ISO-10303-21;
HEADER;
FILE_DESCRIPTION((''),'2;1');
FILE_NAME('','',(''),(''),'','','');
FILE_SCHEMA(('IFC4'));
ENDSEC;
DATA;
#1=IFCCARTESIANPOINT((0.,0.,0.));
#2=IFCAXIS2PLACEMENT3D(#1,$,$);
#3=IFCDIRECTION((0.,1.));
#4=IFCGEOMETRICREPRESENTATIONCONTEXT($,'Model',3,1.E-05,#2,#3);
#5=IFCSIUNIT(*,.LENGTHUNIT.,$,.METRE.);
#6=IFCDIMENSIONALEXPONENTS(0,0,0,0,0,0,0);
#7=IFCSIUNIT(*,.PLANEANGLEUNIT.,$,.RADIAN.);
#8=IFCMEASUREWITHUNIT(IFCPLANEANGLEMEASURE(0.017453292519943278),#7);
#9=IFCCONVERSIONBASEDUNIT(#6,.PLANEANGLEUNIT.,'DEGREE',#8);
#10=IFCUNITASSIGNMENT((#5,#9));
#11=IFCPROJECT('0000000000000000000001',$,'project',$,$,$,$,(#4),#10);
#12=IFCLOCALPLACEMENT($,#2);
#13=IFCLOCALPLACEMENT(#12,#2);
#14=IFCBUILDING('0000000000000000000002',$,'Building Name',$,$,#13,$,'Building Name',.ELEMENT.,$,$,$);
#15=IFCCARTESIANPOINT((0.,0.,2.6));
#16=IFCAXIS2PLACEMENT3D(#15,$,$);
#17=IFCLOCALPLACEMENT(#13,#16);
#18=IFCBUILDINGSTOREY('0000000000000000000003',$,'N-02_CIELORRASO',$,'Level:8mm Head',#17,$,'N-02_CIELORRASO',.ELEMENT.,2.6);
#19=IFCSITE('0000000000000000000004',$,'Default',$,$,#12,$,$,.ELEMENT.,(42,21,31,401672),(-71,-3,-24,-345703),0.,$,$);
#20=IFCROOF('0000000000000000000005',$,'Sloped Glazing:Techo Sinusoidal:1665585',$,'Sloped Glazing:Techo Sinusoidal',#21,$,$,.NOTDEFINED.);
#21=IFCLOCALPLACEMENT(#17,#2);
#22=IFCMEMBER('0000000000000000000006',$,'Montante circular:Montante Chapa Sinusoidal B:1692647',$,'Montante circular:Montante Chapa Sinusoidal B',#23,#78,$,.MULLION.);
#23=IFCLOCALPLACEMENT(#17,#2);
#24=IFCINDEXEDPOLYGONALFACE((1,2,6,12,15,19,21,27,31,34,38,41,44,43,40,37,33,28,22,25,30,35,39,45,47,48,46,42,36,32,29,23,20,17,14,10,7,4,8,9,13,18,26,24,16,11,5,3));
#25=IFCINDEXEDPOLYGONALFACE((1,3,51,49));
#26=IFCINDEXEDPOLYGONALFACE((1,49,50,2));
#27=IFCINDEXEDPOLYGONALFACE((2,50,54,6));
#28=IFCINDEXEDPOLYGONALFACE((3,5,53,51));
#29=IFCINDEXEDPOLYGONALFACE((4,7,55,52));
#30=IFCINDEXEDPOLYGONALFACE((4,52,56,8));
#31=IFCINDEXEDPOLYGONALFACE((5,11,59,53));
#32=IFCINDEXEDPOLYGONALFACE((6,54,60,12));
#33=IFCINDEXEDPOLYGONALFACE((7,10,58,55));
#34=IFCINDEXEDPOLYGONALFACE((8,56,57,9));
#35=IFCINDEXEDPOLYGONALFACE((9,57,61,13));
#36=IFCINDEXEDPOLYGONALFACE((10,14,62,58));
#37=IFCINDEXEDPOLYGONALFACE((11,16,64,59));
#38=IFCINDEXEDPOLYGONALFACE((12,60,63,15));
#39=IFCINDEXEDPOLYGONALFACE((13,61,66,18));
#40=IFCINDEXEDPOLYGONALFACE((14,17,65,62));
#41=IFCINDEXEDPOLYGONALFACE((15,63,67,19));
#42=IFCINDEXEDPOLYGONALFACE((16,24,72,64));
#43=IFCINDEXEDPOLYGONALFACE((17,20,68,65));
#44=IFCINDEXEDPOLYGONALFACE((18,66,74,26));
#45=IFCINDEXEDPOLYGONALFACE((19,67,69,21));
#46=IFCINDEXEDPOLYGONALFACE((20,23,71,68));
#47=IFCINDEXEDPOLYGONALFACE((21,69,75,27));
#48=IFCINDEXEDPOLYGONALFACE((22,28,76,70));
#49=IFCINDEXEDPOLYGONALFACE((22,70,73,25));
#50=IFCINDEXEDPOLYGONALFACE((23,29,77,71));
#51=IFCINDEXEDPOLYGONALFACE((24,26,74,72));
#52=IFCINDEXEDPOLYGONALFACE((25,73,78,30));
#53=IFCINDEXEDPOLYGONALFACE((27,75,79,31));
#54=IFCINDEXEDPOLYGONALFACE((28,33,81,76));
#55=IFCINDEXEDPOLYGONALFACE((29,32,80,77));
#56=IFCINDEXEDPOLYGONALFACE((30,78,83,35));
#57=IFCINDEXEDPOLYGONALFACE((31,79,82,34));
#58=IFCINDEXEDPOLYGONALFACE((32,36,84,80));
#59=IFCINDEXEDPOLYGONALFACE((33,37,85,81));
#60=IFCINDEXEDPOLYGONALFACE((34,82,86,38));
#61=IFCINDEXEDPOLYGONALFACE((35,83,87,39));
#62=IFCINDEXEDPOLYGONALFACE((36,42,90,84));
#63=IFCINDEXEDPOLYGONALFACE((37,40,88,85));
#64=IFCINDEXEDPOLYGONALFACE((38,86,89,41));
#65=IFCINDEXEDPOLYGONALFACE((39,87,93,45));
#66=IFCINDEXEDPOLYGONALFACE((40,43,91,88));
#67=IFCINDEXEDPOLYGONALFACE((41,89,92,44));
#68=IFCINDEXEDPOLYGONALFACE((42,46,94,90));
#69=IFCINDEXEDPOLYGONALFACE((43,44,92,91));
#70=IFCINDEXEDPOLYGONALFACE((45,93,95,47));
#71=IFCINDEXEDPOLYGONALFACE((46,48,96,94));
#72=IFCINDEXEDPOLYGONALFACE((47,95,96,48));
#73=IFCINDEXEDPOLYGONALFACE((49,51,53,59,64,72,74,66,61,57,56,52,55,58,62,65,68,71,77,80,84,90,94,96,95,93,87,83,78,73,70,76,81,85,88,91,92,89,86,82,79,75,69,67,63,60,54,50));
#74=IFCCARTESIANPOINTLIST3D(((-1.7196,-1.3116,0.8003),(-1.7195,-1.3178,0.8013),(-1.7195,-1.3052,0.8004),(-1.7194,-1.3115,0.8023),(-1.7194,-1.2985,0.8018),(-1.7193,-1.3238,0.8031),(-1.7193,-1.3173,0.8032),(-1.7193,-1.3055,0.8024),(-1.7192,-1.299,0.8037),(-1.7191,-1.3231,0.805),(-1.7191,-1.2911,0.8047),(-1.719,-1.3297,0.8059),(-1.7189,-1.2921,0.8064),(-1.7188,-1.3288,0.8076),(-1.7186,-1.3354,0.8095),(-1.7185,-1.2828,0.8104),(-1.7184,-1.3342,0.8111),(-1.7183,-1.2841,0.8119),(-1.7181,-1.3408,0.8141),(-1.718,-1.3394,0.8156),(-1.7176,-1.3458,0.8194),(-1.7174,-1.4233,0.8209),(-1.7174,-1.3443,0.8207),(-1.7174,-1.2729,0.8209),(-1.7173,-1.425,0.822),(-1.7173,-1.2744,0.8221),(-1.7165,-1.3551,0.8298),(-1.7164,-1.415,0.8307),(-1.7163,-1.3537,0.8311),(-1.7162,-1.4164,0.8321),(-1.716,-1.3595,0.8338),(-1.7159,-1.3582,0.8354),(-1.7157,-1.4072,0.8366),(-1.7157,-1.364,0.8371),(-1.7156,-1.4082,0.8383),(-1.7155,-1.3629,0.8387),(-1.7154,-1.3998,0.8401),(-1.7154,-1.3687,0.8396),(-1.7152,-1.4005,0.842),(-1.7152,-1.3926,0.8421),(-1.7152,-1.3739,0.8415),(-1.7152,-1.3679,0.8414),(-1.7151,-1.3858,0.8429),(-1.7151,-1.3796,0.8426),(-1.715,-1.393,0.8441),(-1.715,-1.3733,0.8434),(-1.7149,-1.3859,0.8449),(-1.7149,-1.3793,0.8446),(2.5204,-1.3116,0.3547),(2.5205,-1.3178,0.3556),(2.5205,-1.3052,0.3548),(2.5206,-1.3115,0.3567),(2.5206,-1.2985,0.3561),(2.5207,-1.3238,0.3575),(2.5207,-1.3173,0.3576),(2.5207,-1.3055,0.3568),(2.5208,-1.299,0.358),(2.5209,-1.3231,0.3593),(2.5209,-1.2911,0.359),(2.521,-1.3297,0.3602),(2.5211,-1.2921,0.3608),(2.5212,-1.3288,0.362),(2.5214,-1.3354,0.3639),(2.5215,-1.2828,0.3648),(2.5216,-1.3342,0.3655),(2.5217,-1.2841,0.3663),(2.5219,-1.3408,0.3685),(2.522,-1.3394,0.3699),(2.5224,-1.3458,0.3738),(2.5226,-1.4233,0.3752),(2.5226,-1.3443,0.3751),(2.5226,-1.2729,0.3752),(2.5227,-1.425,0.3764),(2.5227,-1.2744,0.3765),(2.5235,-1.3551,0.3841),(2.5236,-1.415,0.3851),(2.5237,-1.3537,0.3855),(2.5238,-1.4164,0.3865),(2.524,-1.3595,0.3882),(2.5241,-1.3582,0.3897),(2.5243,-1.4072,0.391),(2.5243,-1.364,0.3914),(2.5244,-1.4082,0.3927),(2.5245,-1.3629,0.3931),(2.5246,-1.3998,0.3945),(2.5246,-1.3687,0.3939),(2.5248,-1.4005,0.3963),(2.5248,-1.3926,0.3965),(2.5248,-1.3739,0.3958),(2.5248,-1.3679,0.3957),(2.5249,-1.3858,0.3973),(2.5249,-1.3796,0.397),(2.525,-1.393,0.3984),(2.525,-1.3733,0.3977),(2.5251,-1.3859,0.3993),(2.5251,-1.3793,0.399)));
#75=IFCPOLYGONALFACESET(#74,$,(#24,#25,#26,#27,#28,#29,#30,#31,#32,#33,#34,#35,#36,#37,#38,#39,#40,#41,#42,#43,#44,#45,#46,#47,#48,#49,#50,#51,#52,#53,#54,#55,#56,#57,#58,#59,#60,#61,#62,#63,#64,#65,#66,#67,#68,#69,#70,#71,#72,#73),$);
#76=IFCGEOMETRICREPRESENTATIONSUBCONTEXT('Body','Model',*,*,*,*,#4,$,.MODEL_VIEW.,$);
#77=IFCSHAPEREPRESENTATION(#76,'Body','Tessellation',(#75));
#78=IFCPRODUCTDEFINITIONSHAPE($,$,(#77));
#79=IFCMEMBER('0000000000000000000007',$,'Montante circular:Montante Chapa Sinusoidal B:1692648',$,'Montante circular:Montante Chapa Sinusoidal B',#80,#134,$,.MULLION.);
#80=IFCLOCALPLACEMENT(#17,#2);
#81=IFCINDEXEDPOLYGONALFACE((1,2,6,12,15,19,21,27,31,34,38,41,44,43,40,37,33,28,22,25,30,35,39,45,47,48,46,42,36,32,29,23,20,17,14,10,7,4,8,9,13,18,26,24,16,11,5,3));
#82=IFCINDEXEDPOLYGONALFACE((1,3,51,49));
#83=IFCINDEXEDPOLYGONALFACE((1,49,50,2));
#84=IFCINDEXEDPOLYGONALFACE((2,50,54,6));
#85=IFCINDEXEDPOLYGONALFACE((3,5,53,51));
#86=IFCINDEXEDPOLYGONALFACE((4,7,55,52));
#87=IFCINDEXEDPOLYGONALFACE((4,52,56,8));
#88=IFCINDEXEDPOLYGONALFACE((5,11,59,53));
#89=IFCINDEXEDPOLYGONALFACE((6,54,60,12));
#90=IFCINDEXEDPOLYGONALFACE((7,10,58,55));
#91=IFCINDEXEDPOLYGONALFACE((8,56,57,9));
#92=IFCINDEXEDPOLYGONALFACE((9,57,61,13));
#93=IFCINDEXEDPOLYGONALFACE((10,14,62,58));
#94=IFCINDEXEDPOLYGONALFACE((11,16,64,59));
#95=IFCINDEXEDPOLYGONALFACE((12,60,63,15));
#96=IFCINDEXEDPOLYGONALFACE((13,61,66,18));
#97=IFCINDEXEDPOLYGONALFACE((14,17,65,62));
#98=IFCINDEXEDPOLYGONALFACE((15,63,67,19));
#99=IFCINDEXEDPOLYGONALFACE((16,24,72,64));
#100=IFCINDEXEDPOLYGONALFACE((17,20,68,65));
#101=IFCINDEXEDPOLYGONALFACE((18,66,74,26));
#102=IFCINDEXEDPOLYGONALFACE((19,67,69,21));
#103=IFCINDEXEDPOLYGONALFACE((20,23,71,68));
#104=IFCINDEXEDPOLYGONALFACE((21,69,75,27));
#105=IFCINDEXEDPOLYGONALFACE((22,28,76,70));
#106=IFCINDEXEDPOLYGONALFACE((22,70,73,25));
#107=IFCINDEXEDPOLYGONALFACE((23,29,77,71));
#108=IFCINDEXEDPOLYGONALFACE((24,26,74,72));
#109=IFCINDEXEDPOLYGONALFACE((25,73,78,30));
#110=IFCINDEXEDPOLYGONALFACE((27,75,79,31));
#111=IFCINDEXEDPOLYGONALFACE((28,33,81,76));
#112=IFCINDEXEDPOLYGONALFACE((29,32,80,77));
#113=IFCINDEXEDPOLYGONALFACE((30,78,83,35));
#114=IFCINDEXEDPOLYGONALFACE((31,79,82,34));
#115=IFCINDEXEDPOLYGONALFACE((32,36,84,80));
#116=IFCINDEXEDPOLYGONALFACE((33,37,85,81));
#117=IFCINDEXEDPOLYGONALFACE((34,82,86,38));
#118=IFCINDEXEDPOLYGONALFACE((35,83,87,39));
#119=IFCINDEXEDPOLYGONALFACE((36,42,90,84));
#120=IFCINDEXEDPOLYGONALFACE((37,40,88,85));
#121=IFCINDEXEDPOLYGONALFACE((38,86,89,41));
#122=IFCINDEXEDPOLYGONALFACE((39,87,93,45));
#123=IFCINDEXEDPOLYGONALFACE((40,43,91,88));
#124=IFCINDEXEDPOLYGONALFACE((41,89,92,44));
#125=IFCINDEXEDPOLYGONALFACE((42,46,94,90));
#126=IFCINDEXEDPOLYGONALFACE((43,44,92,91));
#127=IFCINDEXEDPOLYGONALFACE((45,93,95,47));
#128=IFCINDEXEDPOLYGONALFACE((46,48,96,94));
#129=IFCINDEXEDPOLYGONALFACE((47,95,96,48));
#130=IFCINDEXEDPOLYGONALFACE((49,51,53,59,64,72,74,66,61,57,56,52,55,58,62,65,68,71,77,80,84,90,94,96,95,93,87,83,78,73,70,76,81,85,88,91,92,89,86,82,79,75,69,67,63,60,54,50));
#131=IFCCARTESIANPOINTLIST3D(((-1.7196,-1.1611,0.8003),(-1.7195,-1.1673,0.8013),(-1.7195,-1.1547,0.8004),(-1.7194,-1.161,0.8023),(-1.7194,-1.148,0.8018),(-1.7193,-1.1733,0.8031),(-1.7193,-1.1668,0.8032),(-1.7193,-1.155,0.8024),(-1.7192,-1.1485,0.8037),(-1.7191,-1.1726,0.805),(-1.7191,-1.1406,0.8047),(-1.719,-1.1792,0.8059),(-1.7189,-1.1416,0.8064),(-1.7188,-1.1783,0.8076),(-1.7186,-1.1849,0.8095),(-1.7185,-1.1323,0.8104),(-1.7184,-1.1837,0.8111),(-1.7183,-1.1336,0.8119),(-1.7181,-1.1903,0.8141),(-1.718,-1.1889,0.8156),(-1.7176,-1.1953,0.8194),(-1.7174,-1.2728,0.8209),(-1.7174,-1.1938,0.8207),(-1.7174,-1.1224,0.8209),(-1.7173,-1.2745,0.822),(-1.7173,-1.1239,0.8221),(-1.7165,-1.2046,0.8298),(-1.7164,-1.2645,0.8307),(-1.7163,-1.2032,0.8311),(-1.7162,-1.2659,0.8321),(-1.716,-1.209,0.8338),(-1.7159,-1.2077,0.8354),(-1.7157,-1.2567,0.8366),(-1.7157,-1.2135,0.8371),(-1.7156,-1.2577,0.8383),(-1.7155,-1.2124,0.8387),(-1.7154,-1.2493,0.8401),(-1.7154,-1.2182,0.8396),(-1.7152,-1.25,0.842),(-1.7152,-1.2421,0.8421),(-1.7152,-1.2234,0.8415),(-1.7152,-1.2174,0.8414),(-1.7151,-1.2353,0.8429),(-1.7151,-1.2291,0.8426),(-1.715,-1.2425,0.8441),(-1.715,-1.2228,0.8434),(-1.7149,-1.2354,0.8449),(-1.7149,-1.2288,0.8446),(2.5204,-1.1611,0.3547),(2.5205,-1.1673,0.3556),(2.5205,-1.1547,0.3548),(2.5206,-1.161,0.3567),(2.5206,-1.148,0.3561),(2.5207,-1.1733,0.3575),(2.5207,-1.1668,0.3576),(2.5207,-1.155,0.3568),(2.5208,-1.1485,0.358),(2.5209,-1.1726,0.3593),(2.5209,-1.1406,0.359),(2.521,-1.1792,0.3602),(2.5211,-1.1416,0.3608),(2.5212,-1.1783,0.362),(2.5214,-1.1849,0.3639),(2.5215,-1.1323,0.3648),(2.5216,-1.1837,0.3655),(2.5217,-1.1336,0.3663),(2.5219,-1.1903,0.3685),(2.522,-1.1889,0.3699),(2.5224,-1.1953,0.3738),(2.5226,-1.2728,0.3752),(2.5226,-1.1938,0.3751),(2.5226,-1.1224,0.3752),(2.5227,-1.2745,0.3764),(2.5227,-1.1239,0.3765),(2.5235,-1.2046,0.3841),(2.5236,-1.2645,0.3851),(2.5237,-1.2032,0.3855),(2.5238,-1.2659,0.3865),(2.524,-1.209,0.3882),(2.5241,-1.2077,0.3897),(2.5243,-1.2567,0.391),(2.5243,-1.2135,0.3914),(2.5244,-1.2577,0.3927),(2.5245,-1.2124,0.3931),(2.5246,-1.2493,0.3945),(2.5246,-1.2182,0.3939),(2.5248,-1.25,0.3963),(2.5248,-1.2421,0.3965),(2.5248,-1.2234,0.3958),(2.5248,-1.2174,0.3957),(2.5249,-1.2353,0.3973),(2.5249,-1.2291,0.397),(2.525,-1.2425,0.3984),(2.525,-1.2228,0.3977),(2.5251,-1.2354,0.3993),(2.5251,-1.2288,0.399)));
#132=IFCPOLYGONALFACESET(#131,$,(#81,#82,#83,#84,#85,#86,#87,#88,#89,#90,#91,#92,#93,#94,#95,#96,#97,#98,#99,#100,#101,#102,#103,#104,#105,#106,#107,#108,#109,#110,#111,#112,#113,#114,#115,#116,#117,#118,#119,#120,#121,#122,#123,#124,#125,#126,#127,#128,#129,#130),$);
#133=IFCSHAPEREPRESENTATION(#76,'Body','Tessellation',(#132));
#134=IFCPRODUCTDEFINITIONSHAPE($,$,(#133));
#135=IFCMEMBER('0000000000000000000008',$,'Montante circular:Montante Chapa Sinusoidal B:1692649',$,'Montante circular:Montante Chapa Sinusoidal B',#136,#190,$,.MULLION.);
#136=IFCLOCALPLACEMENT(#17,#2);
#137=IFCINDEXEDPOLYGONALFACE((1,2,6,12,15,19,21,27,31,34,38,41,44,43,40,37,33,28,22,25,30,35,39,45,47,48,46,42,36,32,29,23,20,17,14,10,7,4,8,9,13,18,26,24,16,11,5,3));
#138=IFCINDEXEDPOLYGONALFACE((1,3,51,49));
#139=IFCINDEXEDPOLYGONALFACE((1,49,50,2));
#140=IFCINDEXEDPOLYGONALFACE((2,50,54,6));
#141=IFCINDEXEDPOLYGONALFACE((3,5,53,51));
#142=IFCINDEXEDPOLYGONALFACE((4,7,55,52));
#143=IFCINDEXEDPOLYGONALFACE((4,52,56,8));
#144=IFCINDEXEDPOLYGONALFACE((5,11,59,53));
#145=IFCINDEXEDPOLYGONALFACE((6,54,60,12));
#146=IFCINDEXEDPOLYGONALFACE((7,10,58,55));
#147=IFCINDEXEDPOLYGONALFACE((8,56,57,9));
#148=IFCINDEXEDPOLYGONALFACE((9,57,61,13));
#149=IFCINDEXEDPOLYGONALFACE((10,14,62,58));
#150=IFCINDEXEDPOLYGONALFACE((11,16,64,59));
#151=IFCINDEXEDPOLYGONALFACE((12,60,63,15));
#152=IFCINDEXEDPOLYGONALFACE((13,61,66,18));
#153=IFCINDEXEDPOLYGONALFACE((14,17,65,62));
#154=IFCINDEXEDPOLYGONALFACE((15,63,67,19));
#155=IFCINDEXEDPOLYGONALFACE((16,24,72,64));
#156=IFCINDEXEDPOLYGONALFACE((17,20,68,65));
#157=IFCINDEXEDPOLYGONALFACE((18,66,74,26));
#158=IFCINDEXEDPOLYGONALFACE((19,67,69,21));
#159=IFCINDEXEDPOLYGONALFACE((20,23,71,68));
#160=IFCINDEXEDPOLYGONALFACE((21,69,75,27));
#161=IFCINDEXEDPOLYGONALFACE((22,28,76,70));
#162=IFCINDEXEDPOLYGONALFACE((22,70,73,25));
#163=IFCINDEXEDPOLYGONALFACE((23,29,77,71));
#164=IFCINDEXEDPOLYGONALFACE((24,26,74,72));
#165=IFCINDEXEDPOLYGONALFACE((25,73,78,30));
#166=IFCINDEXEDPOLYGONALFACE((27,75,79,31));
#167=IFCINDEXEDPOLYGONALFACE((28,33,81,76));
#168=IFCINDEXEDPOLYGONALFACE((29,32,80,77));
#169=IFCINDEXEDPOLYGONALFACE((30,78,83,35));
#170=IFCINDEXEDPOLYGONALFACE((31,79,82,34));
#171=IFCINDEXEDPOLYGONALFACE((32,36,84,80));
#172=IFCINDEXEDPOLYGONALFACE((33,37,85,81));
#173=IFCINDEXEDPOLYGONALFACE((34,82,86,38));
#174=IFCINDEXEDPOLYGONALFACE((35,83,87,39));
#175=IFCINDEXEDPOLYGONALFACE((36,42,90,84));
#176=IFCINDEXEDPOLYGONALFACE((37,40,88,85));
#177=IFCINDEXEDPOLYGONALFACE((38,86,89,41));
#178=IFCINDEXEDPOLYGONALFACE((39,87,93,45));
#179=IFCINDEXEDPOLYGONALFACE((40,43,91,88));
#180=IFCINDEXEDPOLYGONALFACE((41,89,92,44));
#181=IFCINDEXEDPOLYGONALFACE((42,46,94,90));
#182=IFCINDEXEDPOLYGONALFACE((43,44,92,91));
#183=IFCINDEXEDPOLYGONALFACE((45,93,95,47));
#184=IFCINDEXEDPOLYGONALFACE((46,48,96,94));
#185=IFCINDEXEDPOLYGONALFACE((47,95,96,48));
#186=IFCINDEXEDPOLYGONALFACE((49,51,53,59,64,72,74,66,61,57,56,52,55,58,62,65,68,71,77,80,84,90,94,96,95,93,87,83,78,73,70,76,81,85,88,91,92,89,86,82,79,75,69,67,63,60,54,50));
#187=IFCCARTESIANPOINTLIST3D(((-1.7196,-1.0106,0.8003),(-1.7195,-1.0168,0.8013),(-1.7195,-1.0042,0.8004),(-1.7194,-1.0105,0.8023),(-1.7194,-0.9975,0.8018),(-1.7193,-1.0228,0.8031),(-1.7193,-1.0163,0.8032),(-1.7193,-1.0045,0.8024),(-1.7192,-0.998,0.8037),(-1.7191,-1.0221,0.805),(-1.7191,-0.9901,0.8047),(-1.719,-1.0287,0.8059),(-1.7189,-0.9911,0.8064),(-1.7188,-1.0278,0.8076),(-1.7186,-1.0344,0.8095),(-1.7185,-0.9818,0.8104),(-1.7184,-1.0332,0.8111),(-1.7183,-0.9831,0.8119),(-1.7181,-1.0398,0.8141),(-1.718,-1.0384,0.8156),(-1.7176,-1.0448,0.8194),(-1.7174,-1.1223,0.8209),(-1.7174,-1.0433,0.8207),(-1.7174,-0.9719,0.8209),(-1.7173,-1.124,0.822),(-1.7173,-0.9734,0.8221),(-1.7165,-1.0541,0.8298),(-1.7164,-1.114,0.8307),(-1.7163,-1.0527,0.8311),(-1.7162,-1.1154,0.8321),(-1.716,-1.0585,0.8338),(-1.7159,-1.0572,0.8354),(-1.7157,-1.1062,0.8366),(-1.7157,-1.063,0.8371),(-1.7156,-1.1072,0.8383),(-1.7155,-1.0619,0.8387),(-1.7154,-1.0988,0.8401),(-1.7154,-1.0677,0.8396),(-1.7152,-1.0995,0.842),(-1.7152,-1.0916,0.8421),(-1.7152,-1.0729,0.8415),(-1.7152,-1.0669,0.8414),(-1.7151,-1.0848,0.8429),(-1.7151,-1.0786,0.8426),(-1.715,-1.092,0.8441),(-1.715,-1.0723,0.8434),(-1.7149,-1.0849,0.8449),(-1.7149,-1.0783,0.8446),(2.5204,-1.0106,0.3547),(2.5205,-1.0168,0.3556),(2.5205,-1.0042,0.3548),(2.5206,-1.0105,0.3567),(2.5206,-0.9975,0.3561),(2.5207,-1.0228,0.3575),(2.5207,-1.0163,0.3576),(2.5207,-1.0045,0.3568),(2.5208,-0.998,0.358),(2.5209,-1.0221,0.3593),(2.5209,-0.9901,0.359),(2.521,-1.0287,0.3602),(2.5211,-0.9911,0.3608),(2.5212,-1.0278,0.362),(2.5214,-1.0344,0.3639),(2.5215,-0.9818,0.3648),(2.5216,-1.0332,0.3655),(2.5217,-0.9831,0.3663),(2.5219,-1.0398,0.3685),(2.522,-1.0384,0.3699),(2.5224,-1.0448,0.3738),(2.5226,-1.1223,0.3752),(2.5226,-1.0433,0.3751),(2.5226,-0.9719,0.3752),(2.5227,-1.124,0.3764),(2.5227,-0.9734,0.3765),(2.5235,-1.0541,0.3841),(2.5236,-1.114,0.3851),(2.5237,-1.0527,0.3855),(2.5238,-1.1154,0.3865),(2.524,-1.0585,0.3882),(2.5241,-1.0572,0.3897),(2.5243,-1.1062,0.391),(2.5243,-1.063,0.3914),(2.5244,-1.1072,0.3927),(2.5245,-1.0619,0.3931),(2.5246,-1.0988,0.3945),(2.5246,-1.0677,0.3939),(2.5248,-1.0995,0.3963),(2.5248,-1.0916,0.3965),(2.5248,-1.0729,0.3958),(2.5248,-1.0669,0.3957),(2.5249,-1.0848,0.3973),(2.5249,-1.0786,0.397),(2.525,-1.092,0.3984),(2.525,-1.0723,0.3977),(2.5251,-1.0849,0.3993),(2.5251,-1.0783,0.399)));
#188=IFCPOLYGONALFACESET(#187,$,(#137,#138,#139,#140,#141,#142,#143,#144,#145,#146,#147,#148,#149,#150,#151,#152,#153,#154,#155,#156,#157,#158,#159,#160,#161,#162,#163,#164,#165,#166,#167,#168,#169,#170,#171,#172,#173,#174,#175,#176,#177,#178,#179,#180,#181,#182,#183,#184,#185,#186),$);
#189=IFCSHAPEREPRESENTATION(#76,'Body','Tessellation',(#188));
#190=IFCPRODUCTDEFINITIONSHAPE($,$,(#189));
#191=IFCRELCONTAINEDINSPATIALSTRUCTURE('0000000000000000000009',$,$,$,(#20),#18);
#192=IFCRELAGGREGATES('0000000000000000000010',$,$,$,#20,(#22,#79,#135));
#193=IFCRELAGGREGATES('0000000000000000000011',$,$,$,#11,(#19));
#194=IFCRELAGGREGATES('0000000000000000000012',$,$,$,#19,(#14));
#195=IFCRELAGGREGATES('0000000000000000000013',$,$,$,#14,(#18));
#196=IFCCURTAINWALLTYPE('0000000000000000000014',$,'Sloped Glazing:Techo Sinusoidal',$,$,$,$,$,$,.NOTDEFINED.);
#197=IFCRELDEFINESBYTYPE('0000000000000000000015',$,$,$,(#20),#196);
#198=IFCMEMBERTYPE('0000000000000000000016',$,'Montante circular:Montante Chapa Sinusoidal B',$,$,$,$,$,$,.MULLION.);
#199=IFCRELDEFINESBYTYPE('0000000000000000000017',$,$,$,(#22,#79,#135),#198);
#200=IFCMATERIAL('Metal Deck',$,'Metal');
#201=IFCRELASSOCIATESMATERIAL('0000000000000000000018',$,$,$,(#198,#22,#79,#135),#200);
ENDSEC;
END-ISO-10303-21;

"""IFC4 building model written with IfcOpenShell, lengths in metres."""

from ifc_helpers import new_model, entity, si_unit, converted_unit, direction, frame, origin, place, context, subcontext, project, spatial, indexed_curve, outline, extrude, source, transform, mapped, material, type_object, type_shapes, element, aggregate, save


model = new_model("IFC4")

# Units and contexts
model_context = context("Model", 3, precision=1e-05, world=origin(), true_north=direction((0.0, 1.0)))
body_context = subcontext(model_context, "Body", "Model", "MODEL_VIEW")
ifc_project = project(units=[si_unit("LENGTHUNIT", "METRE"), converted_unit("PLANEANGLEUNIT", "DEGREE", entity("IfcPlaneAngleMeasure", 0.017453292519943278), si_unit("PLANEANGLEUNIT", "RADIAN"), dimensions=[0, 0, 0, 0, 0, 0, 0])], contexts=[model_context])

# Site, building, storey
site_placement = place(None, origin())
site = spatial("IfcSite", under=ifc_project, at=site_placement, Name="Default", CompositionType="ELEMENT", RefLatitude=(42, 21, 31, 401672), RefLongitude=(-71, -3, -24, -345703), RefElevation=0.0)
building_placement = place(site_placement, origin())
building = spatial("IfcBuilding", under=site, at=building_placement, Name="Building Name", LongName="Building Name", CompositionType="ELEMENT")
storey_placement = place(building_placement, frame((0.0, 0.0, 2.6)))
storey = spatial("IfcBuildingStorey", under=building, at=storey_placement, Name="N-02_CIELORRASO", ObjectType="Level:8mm Head", LongName="N-02_CIELORRASO", CompositionType="ELEMENT", Elevation=2.6)

# Roof, members
curtain_wall_type = type_object("IfcCurtainWallType", Name="Sloped Glazing:Techo Sinusoidal", PredefinedType="NOTDEFINED")
roof_1_placement = place(storey_placement, frame((0.0, 0.0, -2.6)))
roof_1 = element("IfcRoof", 1, at=roof_1_placement, inside=storey, type_object=curtain_wall_type, Name="Sloped Glazing:Techo Sinusoidal:1665585", ObjectType="Sloped Glazing:Techo Sinusoidal", PredefinedType="NOTDEFINED")
ifc_material = material(Name="Metal Deck", Category="Metal")
member_type_1 = type_object("IfcMemberType", Name="Montante circular:Montante Chapa Sinusoidal B", PredefinedType="MULLION", material=ifc_material)
shared_shape_1 = source(origin(), body_context, "Body", "SweptSolid", [
    extrude(outline(indexed_curve([(0.0595, -0.0443), (0.0615, -0.0443), (0.0603, -0.031), (0.0572, -0.0213), (0.053, -0.0138), (0.0481, -0.0078), (0.0427, -0.003), (0.0372, 0.0005), (0.0315, 0.0029), (0.0259, 0.0044), (0.0203, 0.0051), (0.0146, 0.005), (0.0084, 0.0041), (-0.0053, 0.0009), (-0.0123, -0.0005), (-0.0191, -0.0012), (-0.0256, -0.001), (-0.0317, 0.0001), (-0.0375, 0.0019), (-0.0428, 0.0046), (-0.0477, 0.0081), (-0.0522, 0.0128), (-0.0563, 0.0191), (-0.0597, 0.0282), (-0.0617, 0.0421), (-0.0637, 0.042), (-0.0616, 0.0277), (-0.0581, 0.0182), (-0.0537, 0.0116), (-0.049, 0.0066), (-0.0438, 0.0028), (-0.0382, 0.0001), (-0.0322, -0.0019), (-0.0258, -0.003), (-0.019, -0.0032), (-0.012, -0.0025), (-0.0048, -0.0011), (0.0088, 0.0021), (0.0147, 0.003), (0.0202, 0.0031), (0.0255, 0.0024), (0.0309, 0.001), (0.0362, -0.0013), (0.0415, -0.0046), (0.0466, -0.0092), (0.0513, -0.0149), (0.0554, -0.0221), (0.0584, -0.0314), (0.0595, -0.0443)], self_intersect=False)), frame((-0.007, 0.0228, -4.2634), z_axis=(0.0, 0.0, 1.0), x_axis=(-0.819152, -0.573576, 0.0)), (0.0, 0.0, 1.0), 4.2634),
])
type_shapes(member_type_1, [shared_shape_1])
member_1_placement = place(roof_1_placement, frame((-1.7148, -1.3421, 3.4456), z_axis=(-0.994522, 0.0, 0.104528), x_axis=(0.0, 1.0, 0.0)))
member_1 = element("IfcMember", 2, at=member_1_placement, type_object=member_type_1, material=ifc_material, Name="Montante circular:Montante Chapa Sinusoidal B:1692647", ObjectType="Montante circular:Montante Chapa Sinusoidal B", PredefinedType="MULLION", context=body_context, shape_type="MappedRepresentation", body=[
    mapped(shared_shape_1, transform((0.0, 0.0, 0.0), scale=1.0)),
])
member_2_placement = place(roof_1_placement, frame((-1.7148, -1.1916, 3.4456), z_axis=(-0.994522, 0.0, 0.104528), x_axis=(0.0, 1.0, 0.0)))
member_2 = element("IfcMember", 3, at=member_2_placement, type_object=member_type_1, material=ifc_material, Name="Montante circular:Montante Chapa Sinusoidal B:1692648", ObjectType="Montante circular:Montante Chapa Sinusoidal B", PredefinedType="MULLION", context=body_context, shape_type="MappedRepresentation", body=[
    mapped(shared_shape_1, transform((0.0, 0.0, 0.0), scale=1.0)),
])
member_3_placement = place(roof_1_placement, frame((-1.7148, -1.0411, 3.4456), z_axis=(-0.994522, 0.0, 0.104528), x_axis=(0.0, 1.0, 0.0)))
member_3 = element("IfcMember", 4, at=member_3_placement, type_object=member_type_1, material=ifc_material, Name="Montante circular:Montante Chapa Sinusoidal B:1692649", ObjectType="Montante circular:Montante Chapa Sinusoidal B", PredefinedType="MULLION", context=body_context, shape_type="MappedRepresentation", body=[
    mapped(shared_shape_1, transform((0.0, 0.0, 0.0), scale=1.0)),
])
aggregate(roof_1, [member_1, member_2, member_3])

save(model, "model.ifc")
